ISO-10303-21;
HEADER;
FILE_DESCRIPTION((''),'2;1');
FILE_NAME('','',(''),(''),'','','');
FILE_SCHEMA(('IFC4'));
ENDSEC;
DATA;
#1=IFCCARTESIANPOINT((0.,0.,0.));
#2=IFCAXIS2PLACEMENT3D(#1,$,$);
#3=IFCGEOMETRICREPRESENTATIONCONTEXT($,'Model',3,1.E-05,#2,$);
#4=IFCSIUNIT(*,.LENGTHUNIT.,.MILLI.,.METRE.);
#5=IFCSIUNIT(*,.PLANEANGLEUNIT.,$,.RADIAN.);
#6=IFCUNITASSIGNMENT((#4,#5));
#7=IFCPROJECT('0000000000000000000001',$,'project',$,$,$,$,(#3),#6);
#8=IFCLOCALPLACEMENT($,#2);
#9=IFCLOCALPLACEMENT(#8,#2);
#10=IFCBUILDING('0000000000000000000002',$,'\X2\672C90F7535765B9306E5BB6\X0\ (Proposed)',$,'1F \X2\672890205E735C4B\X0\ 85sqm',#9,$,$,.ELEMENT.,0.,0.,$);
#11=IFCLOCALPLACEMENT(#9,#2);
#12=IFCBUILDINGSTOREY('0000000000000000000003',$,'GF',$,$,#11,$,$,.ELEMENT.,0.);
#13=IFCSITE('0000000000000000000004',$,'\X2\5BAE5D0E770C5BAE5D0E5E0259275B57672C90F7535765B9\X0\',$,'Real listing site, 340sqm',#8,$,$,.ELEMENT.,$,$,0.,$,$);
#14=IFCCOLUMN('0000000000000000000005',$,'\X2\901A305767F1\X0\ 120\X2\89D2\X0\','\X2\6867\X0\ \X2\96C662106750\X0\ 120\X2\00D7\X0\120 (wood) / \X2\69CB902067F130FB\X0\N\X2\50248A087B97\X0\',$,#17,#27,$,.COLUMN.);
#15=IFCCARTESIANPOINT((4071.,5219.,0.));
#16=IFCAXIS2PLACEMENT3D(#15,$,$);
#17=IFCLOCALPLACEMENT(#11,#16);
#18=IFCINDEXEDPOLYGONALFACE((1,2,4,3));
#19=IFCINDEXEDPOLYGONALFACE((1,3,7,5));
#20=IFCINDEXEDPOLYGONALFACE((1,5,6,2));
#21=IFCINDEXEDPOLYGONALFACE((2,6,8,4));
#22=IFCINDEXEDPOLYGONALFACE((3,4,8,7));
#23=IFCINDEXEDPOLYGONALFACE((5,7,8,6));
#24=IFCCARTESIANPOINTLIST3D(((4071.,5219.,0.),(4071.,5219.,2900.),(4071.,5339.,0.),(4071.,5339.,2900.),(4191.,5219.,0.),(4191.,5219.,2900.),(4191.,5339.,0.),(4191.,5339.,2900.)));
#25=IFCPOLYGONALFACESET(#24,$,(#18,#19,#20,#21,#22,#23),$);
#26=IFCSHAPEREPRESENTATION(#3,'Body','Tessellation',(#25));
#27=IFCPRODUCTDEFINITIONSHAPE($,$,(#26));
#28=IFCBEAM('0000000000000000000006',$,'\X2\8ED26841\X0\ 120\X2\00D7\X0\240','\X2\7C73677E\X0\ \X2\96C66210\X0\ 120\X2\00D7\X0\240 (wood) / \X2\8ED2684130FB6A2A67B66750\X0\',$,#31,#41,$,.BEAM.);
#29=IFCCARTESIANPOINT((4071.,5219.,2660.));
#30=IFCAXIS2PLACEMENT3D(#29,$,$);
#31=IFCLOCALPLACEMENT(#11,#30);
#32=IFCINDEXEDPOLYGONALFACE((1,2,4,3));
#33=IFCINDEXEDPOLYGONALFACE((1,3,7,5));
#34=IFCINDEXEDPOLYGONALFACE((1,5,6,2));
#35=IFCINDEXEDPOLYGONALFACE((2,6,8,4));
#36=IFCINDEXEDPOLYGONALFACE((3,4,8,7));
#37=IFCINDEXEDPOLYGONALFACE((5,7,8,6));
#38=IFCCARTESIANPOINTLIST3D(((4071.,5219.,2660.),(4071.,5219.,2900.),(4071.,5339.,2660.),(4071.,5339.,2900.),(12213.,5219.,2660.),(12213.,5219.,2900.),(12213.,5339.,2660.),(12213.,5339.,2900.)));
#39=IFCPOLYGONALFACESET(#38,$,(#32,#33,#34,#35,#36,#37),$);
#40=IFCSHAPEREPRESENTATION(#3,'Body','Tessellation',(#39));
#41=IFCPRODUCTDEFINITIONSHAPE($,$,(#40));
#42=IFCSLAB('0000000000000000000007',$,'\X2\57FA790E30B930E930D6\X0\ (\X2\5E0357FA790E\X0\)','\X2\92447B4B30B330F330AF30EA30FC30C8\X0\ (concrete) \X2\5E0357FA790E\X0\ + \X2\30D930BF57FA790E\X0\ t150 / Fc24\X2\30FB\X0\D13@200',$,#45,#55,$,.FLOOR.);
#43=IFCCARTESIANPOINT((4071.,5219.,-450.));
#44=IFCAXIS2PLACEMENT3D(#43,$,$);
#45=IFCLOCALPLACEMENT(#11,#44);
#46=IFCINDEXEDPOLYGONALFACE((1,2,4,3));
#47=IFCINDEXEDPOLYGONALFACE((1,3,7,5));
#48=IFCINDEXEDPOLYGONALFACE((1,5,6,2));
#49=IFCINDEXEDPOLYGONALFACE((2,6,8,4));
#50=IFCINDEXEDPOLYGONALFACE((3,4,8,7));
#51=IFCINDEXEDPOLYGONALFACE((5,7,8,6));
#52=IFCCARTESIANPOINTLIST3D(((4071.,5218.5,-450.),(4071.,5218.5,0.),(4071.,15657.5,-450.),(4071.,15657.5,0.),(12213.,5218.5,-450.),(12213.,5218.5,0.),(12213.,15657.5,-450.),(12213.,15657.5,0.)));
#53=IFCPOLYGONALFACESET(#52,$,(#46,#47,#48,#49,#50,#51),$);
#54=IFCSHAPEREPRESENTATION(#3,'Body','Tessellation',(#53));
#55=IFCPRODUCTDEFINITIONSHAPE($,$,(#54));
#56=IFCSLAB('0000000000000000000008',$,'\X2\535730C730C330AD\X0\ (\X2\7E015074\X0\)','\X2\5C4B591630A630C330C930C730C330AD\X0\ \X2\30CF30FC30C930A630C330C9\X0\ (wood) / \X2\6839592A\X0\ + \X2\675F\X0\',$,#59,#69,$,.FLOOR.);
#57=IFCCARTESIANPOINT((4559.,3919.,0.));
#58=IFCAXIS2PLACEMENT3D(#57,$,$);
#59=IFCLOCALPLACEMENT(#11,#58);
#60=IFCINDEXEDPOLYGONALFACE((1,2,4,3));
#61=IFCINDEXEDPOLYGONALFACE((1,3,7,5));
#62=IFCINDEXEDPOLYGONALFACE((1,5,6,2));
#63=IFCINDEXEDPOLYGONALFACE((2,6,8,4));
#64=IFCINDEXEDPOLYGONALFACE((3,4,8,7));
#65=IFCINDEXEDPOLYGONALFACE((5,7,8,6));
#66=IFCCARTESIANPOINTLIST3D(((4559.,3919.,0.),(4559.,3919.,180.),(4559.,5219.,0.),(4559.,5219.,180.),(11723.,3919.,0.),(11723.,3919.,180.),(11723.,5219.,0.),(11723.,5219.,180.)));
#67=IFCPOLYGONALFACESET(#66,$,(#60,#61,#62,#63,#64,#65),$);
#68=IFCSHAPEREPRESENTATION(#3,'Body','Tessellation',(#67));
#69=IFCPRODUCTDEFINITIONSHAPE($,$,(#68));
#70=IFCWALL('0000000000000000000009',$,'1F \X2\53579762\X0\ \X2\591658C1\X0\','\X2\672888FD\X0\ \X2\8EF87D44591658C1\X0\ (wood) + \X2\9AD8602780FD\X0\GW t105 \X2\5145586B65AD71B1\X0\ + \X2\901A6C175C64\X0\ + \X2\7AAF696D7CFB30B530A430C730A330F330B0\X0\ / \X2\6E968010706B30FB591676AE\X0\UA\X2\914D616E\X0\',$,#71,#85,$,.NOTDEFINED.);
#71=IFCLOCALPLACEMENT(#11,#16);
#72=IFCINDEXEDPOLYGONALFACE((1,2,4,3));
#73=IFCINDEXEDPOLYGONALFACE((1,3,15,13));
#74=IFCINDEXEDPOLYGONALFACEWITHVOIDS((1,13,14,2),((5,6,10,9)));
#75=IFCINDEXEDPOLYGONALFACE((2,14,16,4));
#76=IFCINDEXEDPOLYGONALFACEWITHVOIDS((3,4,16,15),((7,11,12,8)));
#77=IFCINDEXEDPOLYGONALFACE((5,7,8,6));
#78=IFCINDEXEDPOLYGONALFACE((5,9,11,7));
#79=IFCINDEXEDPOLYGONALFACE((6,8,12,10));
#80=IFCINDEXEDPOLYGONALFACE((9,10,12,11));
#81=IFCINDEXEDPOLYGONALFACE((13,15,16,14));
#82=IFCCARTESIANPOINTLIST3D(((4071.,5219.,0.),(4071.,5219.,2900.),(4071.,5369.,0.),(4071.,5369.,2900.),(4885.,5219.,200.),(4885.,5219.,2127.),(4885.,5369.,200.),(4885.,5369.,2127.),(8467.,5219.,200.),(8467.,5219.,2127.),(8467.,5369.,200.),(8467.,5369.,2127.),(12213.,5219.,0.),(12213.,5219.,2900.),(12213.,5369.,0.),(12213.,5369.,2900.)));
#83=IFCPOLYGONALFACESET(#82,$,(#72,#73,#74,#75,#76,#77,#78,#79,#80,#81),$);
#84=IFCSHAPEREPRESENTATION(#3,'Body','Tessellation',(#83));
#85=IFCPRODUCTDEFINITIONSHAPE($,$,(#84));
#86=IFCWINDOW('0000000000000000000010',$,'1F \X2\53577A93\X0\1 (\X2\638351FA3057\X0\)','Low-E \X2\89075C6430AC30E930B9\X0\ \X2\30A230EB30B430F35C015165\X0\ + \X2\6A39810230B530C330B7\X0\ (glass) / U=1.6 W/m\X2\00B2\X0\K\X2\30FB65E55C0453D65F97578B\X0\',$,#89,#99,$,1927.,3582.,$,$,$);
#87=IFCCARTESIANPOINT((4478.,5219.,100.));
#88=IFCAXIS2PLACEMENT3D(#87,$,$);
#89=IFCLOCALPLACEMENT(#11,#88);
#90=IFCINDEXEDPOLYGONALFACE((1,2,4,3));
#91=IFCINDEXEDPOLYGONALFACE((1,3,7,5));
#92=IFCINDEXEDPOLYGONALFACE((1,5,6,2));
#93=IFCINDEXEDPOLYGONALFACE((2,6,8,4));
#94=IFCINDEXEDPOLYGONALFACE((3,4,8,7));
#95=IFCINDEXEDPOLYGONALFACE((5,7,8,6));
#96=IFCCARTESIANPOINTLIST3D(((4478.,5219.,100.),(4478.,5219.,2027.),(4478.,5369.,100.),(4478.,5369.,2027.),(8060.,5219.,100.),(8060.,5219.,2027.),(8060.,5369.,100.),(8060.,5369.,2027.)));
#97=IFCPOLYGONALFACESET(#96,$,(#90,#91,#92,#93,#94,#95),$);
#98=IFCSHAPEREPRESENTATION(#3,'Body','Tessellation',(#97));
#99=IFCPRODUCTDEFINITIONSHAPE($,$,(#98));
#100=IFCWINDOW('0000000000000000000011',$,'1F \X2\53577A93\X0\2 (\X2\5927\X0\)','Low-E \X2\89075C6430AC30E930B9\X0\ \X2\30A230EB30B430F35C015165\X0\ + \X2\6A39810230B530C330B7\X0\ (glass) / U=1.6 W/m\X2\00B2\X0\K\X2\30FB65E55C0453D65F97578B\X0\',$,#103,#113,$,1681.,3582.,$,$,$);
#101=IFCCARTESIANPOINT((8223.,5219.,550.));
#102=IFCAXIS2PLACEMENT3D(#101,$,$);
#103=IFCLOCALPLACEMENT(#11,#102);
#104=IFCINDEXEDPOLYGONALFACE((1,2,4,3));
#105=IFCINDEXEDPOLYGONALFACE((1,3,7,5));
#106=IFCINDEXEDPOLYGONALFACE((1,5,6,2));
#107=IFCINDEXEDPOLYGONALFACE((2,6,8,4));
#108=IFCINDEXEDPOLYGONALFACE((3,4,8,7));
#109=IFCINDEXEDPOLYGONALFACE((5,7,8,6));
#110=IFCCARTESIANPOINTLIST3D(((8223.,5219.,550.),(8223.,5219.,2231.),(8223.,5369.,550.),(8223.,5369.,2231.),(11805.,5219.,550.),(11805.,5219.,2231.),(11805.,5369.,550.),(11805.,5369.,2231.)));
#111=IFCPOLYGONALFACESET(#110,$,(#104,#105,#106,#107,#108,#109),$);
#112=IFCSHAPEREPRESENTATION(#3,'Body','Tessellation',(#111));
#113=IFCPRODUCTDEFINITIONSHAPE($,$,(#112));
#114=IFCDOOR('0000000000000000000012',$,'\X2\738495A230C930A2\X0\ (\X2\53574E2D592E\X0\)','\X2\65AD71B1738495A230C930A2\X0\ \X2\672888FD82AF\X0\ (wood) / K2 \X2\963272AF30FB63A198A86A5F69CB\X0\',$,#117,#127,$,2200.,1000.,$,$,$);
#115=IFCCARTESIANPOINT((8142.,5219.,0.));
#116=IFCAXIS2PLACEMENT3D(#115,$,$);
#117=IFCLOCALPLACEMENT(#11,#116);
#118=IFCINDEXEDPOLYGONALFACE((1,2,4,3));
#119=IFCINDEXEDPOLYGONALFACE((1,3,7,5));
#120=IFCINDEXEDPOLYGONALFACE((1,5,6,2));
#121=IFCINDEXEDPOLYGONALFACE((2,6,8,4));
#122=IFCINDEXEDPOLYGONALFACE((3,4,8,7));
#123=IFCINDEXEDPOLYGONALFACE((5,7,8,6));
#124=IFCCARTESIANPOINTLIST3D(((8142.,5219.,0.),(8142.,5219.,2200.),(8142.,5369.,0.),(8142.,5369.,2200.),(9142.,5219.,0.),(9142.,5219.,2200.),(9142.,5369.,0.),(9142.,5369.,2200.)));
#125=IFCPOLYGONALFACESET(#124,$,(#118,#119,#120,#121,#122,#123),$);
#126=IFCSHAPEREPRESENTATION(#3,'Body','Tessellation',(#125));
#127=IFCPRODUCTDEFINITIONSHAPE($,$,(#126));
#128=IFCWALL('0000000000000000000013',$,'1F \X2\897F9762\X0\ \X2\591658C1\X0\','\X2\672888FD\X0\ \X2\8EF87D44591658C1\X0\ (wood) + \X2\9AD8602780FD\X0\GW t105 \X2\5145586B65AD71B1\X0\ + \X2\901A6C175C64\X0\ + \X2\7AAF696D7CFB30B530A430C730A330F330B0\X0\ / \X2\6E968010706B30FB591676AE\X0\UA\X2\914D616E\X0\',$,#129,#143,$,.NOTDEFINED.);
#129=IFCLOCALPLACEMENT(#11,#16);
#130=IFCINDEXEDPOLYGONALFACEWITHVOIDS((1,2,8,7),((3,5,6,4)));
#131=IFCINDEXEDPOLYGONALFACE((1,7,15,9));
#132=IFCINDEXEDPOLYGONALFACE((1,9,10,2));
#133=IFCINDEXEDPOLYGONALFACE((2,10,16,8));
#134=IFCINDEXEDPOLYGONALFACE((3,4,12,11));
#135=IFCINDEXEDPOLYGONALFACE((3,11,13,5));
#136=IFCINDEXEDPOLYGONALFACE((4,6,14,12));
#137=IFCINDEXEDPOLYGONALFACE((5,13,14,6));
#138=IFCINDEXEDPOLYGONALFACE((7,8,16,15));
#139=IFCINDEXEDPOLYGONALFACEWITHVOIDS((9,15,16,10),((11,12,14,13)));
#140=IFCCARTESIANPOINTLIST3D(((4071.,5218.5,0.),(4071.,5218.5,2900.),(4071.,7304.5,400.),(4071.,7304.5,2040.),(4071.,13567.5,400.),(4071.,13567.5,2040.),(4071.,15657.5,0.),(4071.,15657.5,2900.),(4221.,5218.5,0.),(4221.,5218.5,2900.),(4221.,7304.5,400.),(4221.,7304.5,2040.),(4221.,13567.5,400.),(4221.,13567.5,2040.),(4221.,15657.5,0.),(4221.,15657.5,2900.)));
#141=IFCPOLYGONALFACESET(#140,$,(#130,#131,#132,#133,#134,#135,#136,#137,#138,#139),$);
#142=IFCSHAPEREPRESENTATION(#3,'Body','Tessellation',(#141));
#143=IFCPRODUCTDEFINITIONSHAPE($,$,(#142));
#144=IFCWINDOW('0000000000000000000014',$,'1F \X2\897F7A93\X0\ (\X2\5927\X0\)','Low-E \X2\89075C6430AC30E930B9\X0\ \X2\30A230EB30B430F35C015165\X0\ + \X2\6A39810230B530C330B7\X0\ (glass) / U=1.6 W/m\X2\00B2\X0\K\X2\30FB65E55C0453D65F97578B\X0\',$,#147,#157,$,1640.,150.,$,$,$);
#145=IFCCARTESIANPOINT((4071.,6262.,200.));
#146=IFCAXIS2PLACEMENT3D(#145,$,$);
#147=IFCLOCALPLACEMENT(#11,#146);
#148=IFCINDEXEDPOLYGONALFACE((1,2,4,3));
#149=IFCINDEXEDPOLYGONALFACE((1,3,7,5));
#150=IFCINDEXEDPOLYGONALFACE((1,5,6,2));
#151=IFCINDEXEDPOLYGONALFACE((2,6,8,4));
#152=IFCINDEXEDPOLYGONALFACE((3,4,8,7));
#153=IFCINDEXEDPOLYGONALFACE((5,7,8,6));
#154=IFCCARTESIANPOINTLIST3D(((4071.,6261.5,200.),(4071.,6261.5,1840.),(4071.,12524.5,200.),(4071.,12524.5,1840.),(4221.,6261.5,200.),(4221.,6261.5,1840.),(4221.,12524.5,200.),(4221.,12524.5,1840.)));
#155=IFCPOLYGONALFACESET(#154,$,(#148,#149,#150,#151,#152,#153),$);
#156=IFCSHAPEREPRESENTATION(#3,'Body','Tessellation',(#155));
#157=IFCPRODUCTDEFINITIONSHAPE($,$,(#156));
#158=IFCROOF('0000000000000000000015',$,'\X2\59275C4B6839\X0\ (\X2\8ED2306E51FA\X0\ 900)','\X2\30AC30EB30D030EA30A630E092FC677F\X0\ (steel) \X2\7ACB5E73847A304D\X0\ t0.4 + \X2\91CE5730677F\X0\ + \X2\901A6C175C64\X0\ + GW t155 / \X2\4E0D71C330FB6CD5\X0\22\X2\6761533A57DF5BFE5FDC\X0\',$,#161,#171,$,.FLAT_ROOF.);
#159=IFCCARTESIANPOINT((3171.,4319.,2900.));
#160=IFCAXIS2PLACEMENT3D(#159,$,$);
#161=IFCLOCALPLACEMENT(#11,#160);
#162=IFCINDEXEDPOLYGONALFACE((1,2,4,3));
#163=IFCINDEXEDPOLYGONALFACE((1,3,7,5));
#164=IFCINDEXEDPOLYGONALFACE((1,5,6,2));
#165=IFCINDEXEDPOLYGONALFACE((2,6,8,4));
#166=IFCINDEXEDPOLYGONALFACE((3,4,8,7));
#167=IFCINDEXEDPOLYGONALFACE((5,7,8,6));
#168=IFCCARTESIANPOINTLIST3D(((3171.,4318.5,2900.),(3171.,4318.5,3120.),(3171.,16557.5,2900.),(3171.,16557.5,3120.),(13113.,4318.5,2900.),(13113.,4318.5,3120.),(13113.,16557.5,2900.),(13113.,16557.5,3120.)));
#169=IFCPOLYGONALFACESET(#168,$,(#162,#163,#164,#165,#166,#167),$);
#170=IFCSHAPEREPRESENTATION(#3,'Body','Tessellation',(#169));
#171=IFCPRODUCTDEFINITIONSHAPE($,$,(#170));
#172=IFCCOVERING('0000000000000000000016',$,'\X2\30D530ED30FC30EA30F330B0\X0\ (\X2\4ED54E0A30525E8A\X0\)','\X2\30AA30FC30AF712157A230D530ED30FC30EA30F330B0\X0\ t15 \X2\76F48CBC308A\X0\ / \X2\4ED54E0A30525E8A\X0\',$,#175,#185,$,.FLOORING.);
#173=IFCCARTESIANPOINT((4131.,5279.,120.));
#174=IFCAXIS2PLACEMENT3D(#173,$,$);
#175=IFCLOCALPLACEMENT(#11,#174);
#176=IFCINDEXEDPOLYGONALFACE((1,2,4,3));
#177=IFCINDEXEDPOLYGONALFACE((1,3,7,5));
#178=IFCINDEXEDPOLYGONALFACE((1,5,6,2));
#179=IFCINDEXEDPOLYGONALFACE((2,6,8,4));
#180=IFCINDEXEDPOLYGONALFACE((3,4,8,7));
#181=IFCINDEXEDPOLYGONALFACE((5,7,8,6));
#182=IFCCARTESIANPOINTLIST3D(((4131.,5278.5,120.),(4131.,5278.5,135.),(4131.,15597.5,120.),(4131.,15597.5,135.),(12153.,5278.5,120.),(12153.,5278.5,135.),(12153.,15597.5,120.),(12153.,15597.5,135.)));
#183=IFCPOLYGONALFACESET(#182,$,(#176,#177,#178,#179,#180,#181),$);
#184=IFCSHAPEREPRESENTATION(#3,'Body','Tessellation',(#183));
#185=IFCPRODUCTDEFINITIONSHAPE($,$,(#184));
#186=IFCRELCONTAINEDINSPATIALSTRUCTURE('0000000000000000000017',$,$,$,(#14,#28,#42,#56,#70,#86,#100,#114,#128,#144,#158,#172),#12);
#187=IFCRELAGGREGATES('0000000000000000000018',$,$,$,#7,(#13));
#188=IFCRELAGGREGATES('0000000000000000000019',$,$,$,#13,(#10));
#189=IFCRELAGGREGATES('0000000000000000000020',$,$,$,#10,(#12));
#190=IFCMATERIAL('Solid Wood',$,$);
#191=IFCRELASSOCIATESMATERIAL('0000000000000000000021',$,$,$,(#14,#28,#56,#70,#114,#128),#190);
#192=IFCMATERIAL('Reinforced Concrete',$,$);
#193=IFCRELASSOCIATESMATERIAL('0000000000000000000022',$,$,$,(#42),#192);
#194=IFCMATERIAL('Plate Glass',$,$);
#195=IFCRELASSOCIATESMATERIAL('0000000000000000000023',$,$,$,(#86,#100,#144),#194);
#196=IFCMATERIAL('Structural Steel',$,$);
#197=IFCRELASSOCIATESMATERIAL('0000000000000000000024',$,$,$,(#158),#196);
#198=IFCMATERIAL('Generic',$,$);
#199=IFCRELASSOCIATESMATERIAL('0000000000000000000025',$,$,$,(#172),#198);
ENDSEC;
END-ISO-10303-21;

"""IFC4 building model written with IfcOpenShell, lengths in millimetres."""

from ifc_helpers import new_model, si_unit, frame, frame_2d, origin, place, context, project, spatial, rectangle, extrude, material, element, fill, save


model = new_model("IFC4")

# Units and contexts
model_context = context("Model", 3, precision=1e-05, world=origin())
ifc_project = project(units=[si_unit("LENGTHUNIT", "METRE", prefix="MILLI"), si_unit("PLANEANGLEUNIT", "RADIAN")], contexts=[model_context])

# Site, building, storey
site_placement = place(None, origin())
site = spatial("IfcSite", under=ifc_project, at=site_placement, Name="宮崎県宮崎市大字本郷南方", ObjectType="Real listing site, 340sqm", CompositionType="ELEMENT", RefElevation=0.0)
building_placement = place(site_placement, origin())
building = spatial("IfcBuilding", under=site, at=building_placement, Name="本郷南方の家 (Proposed)", ObjectType="1F 木造平屋 85sqm", CompositionType="ELEMENT", ElevationOfRefHeight=0.0, ElevationOfTerrain=0.0)
storey_placement = place(building_placement, origin())
storey = spatial("IfcBuildingStorey", under=building, at=storey_placement, Name="GF", CompositionType="ELEMENT", Elevation=0.0)

# Column
ifc_material_1 = material(Name="Solid Wood")
column_1_placement = place(storey_placement, frame((4071.0, 5219.0, 0.0)))
element("IfcColumn", 1, at=column_1_placement, inside=storey, material=ifc_material_1, Name="通し柱 120角", Description="桧 集成材 120×120 (wood) / 構造柱・N値計算", PredefinedType="COLUMN", context=model_context, shape_type="SweptSolid", body=[
    extrude(rectangle(XDim=120.0, YDim=120.0, at=frame_2d((60.0, 60.0))), frame((4071.0, 5219.0, 0.0)), (0.0, 0.0, 1.0), 2900.0),
])

# Beam
beam_1_placement = place(storey_placement, frame((4071.0, 5219.0, 2660.0)))
element("IfcBeam", 2, at=beam_1_placement, inside=storey, material=ifc_material_1, Name="軒桁 120×240", Description="米松 集成 120×240 (wood) / 軒桁・横架材", PredefinedType="BEAM", context=model_context, shape_type="SweptSolid", body=[
    extrude(rectangle(XDim=8142.0, YDim=120.0, at=frame_2d((4071.0, 60.0))), frame((4071.0, 5219.0, 2660.0)), (0.0, 0.0, 1.0), 240.0),
])

# Slabs
ifc_material_2 = material(Name="Reinforced Concrete")
slab_1_placement = place(storey_placement, frame((4071.0, 5219.0, -450.0)))
element("IfcSlab", 3, at=slab_1_placement, inside=storey, material=ifc_material_2, Name="基礎スラブ (布基礎)", Description="鉄筋コンクリート (concrete) 布基礎 + ベタ基礎 t150 / Fc24・D13@200", PredefinedType="FLOOR", context=model_context, shape_type="SweptSolid", body=[
    extrude(rectangle(XDim=8142.0, YDim=10439.0, at=frame_2d((4071.0, 5219.0))), frame((4071.0, 5219.0, -450.0)), (0.0, 0.0, 1.0), 450.0),
])
slab_2_placement = place(storey_placement, frame((4559.0, 3919.0, 0.0)))
element("IfcSlab", 4, at=slab_2_placement, inside=storey, material=ifc_material_1, Name="南デッキ (縁側)", Description="屋外ウッドデッキ ハードウッド (wood) / 根太 + 束", PredefinedType="FLOOR", context=model_context, shape_type="SweptSolid", body=[
    extrude(rectangle(XDim=7164.0, YDim=1300.0, at=frame_2d((3582.0, 650.0))), frame((4559.0, 3919.0, 0.0)), (0.0, 0.0, 1.0), 180.0),
])

# Wall, openings, windows, door
wall_1_placement = place(storey_placement, frame((4071.0, 5219.0, 0.0)))
wall_1 = element("IfcWall", 5, at=wall_1_placement, inside=storey, material=ifc_material_1, Name="1F 南面 外壁", Description="木製 軸組外壁 (wood) + 高性能GW t105 充填断熱 + 通気層 + 窯業系サイディング / 準耐火・外皮UA配慮", PredefinedType="NOTDEFINED", context=model_context, shape_type="SweptSolid", body=[
    extrude(rectangle(XDim=8142.0, YDim=150.0, at=frame_2d((4071.0, 75.0))), frame((4071.0, 5219.0, 0.0)), (0.0, 0.0, 1.0), 2900.0),
])
opening_1_placement = place(storey_placement, frame((4478.0, 5219.0, 100.0)))
opening_1 = element("IfcOpeningElement", 6, at=opening_1_placement, cuts=wall_1, PredefinedType="NOTDEFINED", context=model_context, shape_type="SweptSolid", body=[
    extrude(rectangle(XDim=3582.0, YDim=150.0, at=frame_2d((1791.0, 75.0))), frame((4478.0, 5219.0, 100.0)), (0.0, 0.0, 1.0), 1927.0),
])
opening_2_placement = place(storey_placement, frame((8223.0, 5219.0, 550.0)))
opening_2 = element("IfcOpeningElement", 7, at=opening_2_placement, cuts=wall_1, PredefinedType="NOTDEFINED", context=model_context, shape_type="SweptSolid", body=[
    extrude(rectangle(XDim=3582.0, YDim=150.0, at=frame_2d((1791.0, 75.0))), frame((8223.0, 5219.0, 550.0)), (0.0, 0.0, 1.0), 1681.0),
])
opening_3_placement = place(storey_placement, frame((8142.0, 5219.0, 0.0)))
opening_3 = element("IfcOpeningElement", 8, at=opening_3_placement, cuts=wall_1, PredefinedType="NOTDEFINED", context=model_context, shape_type="SweptSolid", body=[
    extrude(rectangle(XDim=1000.0, YDim=150.0, at=frame_2d((500.0, 75.0))), frame((8142.0, 5219.0, 0.0)), (0.0, 0.0, 1.0), 2200.0),
])
ifc_material_3 = material(Name="Plate Glass")
window_1_placement = place(storey_placement, frame((4478.0, 5219.0, 100.0)))
window_1 = element("IfcWindow", 9, at=window_1_placement, inside=storey, material=ifc_material_3, Name="1F 南窓1 (掃出し)", Description="Low-E 複層ガラス アルゴン封入 + 樹脂サッシ (glass) / U=1.6 W/m²K・日射取得型", OverallHeight=1927.0, OverallWidth=3582.0, context=model_context, shape_type="SweptSolid", body=[
    extrude(rectangle(XDim=3582.0, YDim=150.0, at=frame_2d((1791.0, 75.0))), frame((4478.0, 5219.0, 100.0)), (0.0, 0.0, 1.0), 1927.0),
])
fill(opening_1, window_1)
window_2_placement = place(storey_placement, frame((8223.0, 5219.0, 550.0)))
window_2 = element("IfcWindow", 10, at=window_2_placement, inside=storey, material=ifc_material_3, Name="1F 南窓2 (大)", Description="Low-E 複層ガラス アルゴン封入 + 樹脂サッシ (glass) / U=1.6 W/m²K・日射取得型", OverallHeight=1681.0, OverallWidth=3582.0, context=model_context, shape_type="SweptSolid", body=[
    extrude(rectangle(XDim=3582.0, YDim=150.0, at=frame_2d((1791.0, 75.0))), frame((8223.0, 5219.0, 550.0)), (0.0, 0.0, 1.0), 1681.0),
])
fill(opening_2, window_2)
door_placement = place(storey_placement, frame((8142.0, 5219.0, 0.0)))
door = element("IfcDoor", 11, at=door_placement, inside=storey, material=ifc_material_1, Name="玄関ドア (南中央)", Description="断熱玄関ドア 木製芯 (wood) / K2 防犯・採風機構", OverallHeight=2200.0, OverallWidth=1000.0, context=model_context, shape_type="SweptSolid", body=[
    extrude(rectangle(XDim=1000.0, YDim=150.0, at=frame_2d((500.0, 75.0))), frame((8142.0, 5219.0, 0.0)), (0.0, 0.0, 1.0), 2200.0),
])
fill(opening_3, door)

# Wall, opening, window
wall_2_placement = place(storey_placement, frame((4071.0, 5219.0, 0.0)))
wall_2 = element("IfcWall", 12, at=wall_2_placement, inside=storey, material=ifc_material_1, Name="1F 西面 外壁", Description="木製 軸組外壁 (wood) + 高性能GW t105 充填断熱 + 通気層 + 窯業系サイディング / 準耐火・外皮UA配慮", PredefinedType="NOTDEFINED", context=model_context, shape_type="SweptSolid", body=[
    extrude(rectangle(XDim=150.0, YDim=10439.0, at=frame_2d((75.0, 5219.0))), frame((4071.0, 5219.0, 0.0)), (0.0, 0.0, 1.0), 2900.0),
])
opening_4_placement = place(storey_placement, frame((4071.0, 6262.0, 200.0)))
opening_4 = element("IfcOpeningElement", 13, at=opening_4_placement, cuts=wall_2, PredefinedType="NOTDEFINED", context=model_context, shape_type="SweptSolid", body=[
    extrude(rectangle(XDim=150.0, YDim=6263.0, at=frame_2d((75.0, 3131.0))), frame((4071.0, 6262.0, 200.0)), (0.0, 0.0, 1.0), 1640.0),
])
window_3_placement = place(storey_placement, frame((4071.0, 6262.0, 200.0)))
window_3 = element("IfcWindow", 14, at=window_3_placement, inside=storey, material=ifc_material_3, Name="1F 西窓 (大)", Description="Low-E 複層ガラス アルゴン封入 + 樹脂サッシ (glass) / U=1.6 W/m²K・日射取得型", OverallHeight=1640.0, OverallWidth=150.0, context=model_context, shape_type="SweptSolid", body=[
    extrude(rectangle(XDim=150.0, YDim=6263.0, at=frame_2d((75.0, 3131.0))), frame((4071.0, 6262.0, 200.0)), (0.0, 0.0, 1.0), 1640.0),
])
fill(opening_4, window_3)

# Roof
ifc_material_4 = material(Name="Structural Steel")
roof_placement = place(storey_placement, frame((3171.0, 4319.0, 2900.0)))
element("IfcRoof", 15, at=roof_placement, inside=storey, material=ifc_material_4, Name="大屋根 (軒の出 900)", Description="ガルバリウム鋼板 (steel) 立平葺き t0.4 + 野地板 + 通気層 + GW t155 / 不燃・法22条区域対応", PredefinedType="FLAT_ROOF", context=model_context, shape_type="SweptSolid", body=[
    extrude(rectangle(XDim=9942.0, YDim=12239.0, at=frame_2d((4971.0, 6119.0))), frame((3171.0, 4319.0, 2900.0)), (0.0, 0.0, 1.0), 220.0),
])

# Covering
ifc_material_5 = material(Name="Generic")
covering_1_placement = place(storey_placement, frame((4131.0, 5279.0, 120.0)))
element("IfcCovering", 16, at=covering_1_placement, inside=storey, material=ifc_material_5, Name="フローリング (仕上げ床)", Description="オーク無垢フローリング t15 直貼り / 仕上げ床", PredefinedType="FLOORING", context=model_context, shape_type="SweptSolid", body=[
    extrude(rectangle(XDim=8022.0, YDim=10319.0, at=frame_2d((4011.0, 5159.0))), frame((4131.0, 5279.0, 120.0)), (0.0, 0.0, 1.0), 15.0),
])

save(model, "model.ifc")
